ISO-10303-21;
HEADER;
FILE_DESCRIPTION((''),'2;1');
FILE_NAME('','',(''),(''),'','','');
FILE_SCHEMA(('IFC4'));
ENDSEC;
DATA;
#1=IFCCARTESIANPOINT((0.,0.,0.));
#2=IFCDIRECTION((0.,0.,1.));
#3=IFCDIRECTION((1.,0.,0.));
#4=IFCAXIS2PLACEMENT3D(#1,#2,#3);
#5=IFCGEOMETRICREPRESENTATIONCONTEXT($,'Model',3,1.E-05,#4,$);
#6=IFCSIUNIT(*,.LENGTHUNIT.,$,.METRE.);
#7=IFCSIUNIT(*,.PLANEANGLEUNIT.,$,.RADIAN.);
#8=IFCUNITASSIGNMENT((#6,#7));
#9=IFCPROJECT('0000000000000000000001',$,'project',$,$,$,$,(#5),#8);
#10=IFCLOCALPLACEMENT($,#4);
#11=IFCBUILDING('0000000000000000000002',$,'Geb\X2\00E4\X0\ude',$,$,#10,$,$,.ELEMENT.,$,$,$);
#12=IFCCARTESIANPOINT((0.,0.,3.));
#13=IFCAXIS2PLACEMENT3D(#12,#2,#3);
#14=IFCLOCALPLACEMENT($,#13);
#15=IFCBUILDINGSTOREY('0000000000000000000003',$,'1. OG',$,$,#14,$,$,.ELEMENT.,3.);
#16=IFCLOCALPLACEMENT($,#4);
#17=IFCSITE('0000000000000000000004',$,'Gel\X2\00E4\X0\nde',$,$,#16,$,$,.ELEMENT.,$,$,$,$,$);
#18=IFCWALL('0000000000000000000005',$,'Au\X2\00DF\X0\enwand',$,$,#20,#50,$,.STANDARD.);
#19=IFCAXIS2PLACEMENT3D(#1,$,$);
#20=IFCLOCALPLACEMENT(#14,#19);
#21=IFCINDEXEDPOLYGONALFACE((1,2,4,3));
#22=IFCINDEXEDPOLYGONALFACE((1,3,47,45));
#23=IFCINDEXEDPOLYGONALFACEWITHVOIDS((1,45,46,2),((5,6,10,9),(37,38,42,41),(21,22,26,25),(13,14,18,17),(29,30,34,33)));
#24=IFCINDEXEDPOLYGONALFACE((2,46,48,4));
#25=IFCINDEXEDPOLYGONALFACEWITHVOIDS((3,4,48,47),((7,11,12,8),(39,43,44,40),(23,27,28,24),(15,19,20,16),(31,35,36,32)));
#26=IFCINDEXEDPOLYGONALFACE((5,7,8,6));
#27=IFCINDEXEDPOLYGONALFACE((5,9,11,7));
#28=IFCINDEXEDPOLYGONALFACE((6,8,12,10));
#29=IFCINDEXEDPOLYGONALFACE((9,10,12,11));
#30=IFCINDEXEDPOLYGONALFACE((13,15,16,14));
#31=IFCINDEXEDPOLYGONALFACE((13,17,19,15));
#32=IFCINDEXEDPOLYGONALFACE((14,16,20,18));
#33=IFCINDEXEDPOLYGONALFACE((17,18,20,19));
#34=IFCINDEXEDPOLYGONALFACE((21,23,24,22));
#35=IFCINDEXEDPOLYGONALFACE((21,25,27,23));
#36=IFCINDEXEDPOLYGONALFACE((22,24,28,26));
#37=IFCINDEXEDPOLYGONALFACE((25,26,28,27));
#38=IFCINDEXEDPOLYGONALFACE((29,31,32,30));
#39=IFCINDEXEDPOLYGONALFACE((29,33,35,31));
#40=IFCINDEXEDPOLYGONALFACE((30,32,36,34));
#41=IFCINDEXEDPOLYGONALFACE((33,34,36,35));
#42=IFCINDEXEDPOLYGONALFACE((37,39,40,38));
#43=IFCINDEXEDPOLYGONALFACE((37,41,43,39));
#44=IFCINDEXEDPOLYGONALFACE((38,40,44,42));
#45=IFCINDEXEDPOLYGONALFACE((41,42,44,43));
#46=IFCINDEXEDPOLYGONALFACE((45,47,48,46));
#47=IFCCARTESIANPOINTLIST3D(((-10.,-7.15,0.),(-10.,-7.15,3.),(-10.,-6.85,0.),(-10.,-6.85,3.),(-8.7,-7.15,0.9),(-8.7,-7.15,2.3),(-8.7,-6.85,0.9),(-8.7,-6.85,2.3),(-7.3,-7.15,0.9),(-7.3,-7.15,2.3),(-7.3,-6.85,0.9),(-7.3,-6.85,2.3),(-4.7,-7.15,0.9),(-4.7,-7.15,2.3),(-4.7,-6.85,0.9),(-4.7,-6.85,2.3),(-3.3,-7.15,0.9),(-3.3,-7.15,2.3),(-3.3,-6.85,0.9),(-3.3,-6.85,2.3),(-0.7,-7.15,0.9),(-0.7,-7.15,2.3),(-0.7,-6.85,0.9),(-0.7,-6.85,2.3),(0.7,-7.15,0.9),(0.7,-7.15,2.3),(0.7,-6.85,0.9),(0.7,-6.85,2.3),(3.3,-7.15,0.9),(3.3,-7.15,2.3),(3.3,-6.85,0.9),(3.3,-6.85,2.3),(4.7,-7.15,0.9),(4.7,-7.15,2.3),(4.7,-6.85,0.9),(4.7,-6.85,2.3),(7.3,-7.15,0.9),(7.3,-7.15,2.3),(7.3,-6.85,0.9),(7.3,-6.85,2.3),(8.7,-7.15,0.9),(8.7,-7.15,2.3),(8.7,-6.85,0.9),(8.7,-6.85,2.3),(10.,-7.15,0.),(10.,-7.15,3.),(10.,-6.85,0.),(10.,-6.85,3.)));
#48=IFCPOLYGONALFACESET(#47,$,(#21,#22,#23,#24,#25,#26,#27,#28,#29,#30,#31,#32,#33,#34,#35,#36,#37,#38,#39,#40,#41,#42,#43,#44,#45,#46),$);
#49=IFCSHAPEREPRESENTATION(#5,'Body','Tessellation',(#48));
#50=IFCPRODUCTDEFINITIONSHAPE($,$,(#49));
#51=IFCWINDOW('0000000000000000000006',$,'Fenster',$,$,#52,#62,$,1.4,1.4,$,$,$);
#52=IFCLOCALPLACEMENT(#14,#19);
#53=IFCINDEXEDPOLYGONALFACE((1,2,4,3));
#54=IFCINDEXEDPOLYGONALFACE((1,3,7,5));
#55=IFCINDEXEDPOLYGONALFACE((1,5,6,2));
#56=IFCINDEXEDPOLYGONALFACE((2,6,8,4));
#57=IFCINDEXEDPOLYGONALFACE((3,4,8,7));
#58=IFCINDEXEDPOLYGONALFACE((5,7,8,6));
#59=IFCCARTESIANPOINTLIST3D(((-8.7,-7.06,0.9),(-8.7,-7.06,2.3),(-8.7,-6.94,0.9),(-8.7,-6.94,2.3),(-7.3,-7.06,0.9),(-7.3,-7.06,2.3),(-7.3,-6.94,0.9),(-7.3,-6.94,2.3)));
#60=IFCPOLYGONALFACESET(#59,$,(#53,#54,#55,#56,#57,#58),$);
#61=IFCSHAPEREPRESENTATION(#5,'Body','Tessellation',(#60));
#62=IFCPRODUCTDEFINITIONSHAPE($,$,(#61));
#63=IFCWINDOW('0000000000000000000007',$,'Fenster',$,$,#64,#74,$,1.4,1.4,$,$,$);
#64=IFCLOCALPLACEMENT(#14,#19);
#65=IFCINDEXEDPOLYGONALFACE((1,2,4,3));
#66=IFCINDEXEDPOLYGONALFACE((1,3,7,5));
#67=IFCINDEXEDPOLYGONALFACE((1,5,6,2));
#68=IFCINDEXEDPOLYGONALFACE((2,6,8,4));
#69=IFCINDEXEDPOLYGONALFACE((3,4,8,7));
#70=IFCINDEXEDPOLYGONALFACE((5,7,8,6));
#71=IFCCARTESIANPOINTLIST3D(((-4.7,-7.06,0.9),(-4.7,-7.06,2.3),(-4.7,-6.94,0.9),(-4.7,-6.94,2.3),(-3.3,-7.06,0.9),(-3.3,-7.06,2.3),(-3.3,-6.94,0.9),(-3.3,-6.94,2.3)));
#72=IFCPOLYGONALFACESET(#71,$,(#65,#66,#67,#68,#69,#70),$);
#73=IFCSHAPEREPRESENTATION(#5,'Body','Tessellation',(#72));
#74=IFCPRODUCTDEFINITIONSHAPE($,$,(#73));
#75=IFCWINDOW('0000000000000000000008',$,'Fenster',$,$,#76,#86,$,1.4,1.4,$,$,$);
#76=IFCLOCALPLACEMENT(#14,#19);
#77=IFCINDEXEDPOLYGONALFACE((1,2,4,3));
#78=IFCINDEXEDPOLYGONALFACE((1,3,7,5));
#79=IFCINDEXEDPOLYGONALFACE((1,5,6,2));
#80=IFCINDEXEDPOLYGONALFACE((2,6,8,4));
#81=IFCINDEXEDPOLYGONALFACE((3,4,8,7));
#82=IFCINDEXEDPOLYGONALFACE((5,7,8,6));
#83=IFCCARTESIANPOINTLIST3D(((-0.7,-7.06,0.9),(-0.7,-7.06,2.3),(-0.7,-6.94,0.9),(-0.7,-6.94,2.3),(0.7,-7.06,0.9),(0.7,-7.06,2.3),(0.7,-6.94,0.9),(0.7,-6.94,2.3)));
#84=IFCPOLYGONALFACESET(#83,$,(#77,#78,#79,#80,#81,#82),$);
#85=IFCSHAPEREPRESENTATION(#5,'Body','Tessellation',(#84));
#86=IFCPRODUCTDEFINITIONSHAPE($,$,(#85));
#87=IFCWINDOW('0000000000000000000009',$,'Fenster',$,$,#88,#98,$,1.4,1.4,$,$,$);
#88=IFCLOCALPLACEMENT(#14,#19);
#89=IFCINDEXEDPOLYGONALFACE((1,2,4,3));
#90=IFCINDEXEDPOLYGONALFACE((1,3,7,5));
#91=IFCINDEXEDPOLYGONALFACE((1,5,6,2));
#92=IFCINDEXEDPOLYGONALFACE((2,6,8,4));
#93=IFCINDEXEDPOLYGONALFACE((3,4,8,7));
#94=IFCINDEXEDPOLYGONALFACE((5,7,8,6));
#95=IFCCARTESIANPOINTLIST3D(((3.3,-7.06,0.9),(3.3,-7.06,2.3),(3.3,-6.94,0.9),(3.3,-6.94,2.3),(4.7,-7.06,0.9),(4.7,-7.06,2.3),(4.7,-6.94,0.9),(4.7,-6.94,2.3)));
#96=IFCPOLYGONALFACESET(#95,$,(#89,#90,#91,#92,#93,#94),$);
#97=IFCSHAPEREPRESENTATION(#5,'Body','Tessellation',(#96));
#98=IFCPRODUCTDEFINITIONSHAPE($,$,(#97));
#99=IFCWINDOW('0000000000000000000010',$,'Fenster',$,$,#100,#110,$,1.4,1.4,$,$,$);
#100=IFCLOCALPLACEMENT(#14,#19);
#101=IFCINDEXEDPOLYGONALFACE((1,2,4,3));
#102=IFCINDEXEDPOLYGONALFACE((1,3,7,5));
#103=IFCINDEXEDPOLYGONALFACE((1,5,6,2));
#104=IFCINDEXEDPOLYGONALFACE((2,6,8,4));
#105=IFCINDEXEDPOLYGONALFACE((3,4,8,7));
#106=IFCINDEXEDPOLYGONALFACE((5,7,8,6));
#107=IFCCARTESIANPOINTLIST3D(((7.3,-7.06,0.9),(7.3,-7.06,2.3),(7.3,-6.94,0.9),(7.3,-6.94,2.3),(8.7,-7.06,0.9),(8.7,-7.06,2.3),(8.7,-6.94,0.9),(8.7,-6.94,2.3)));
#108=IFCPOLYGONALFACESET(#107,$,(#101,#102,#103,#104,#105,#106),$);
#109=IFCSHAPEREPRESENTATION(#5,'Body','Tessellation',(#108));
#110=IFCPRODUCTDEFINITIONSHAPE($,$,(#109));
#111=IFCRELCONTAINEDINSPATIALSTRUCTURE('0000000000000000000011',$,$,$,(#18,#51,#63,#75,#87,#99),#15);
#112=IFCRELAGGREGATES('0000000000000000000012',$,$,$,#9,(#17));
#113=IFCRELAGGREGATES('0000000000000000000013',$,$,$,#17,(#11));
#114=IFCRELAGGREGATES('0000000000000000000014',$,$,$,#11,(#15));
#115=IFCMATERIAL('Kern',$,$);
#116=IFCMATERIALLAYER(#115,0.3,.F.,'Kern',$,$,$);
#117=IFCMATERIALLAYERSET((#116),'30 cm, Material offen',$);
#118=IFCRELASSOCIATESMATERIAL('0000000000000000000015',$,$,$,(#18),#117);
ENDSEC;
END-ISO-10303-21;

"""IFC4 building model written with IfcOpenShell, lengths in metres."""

from ifc_helpers import new_model, si_unit, frame, origin_with_axes, origin_2d, place, context, project, spatial, rectangle, extrude, material, layer, layer_set, element, fill, save


model = new_model("IFC4")

# Units and contexts
model_context = context("Model", 3, precision=1e-05, world=origin_with_axes())
ifc_project = project(units=[si_unit("LENGTHUNIT", "METRE"), si_unit("PLANEANGLEUNIT", "RADIAN")], contexts=[model_context])

# Site, building, storey
site_placement = place(None, origin_with_axes())
site = spatial("IfcSite", under=ifc_project, at=site_placement, Name="Gelände", CompositionType="ELEMENT")
building_placement = place(None, origin_with_axes())
building = spatial("IfcBuilding", under=site, at=building_placement, Name="Gebäude", CompositionType="ELEMENT")
storey_placement = place(None, frame((0.0, 0.0, 3.0), z_axis=(0.0, 0.0, 1.0), x_axis=(1.0, 0.0, 0.0)))
storey = spatial("IfcBuildingStorey", under=building, at=storey_placement, Name="1. OG", CompositionType="ELEMENT", Elevation=3.0)

# Wall, openings, windows
ifc_material = material(Name="Kern")
ifc_layer = layer(ifc_material, 0.3, ventilated=False, Name="Kern")
ifc_layer_set = layer_set([ifc_layer], Name="30 cm, Material offen")
wall_1_placement = place(None, frame((0.0, -7.0, 3.0), z_axis=(0.0, 0.0, 1.0), x_axis=(1.0, 0.0, 0.0)))
wall_1 = element("IfcWall", 1, at=wall_1_placement, inside=storey, material=ifc_layer_set, Name="Außenwand", PredefinedType="STANDARD", context=model_context, shape_type="SweptSolid", body=[
    extrude(rectangle(XDim=20.0, YDim=0.3, at=origin_2d()), origin_with_axes(), (0.0, 0.0, 1.0), 3.0),
])
opening_1_placement = place(wall_1_placement, frame((-8.0, 0.0, 0.9), z_axis=(0.0, 0.0, 1.0), x_axis=(1.0, 0.0, 0.0)))
opening_1 = element("IfcOpeningElement", 2, at=opening_1_placement, cuts=wall_1, PredefinedType="OPENING", context=model_context, shape_type="SweptSolid", body=[
    extrude(rectangle(XDim=1.4, YDim=0.34, at=origin_2d()), origin_with_axes(), (0.0, 0.0, 1.0), 1.4),
])
opening_2_placement = place(wall_1_placement, frame((-4.0, 0.0, 0.9), z_axis=(0.0, 0.0, 1.0), x_axis=(1.0, 0.0, 0.0)))
opening_2 = element("IfcOpeningElement", 3, at=opening_2_placement, cuts=wall_1, PredefinedType="OPENING", context=model_context, shape_type="SweptSolid", body=[
    extrude(rectangle(XDim=1.4, YDim=0.34, at=origin_2d()), origin_with_axes(), (0.0, 0.0, 1.0), 1.4),
])
opening_3_placement = place(wall_1_placement, frame((0.0, 0.0, 0.9), z_axis=(0.0, 0.0, 1.0), x_axis=(1.0, 0.0, 0.0)))
opening_3 = element("IfcOpeningElement", 4, at=opening_3_placement, cuts=wall_1, PredefinedType="OPENING", context=model_context, shape_type="SweptSolid", body=[
    extrude(rectangle(XDim=1.4, YDim=0.34, at=origin_2d()), origin_with_axes(), (0.0, 0.0, 1.0), 1.4),
])
opening_4_placement = place(wall_1_placement, frame((4.0, 0.0, 0.9), z_axis=(0.0, 0.0, 1.0), x_axis=(1.0, 0.0, 0.0)))
opening_4 = element("IfcOpeningElement", 5, at=opening_4_placement, cuts=wall_1, PredefinedType="OPENING", context=model_context, shape_type="SweptSolid", body=[
    extrude(rectangle(XDim=1.4, YDim=0.34, at=origin_2d()), origin_with_axes(), (0.0, 0.0, 1.0), 1.4),
])
opening_5_placement = place(wall_1_placement, frame((8.0, 0.0, 0.9), z_axis=(0.0, 0.0, 1.0), x_axis=(1.0, 0.0, 0.0)))
opening_5 = element("IfcOpeningElement", 6, at=opening_5_placement, cuts=wall_1, PredefinedType="OPENING", context=model_context, shape_type="SweptSolid", body=[
    extrude(rectangle(XDim=1.4, YDim=0.34, at=origin_2d()), origin_with_axes(), (0.0, 0.0, 1.0), 1.4),
])
window_1_placement = place(opening_1_placement, origin_with_axes())
window_1 = element("IfcWindow", 7, at=window_1_placement, inside=storey, Name="Fenster", OverallHeight=1.4, OverallWidth=1.4, context=model_context, shape_type="SweptSolid", body=[
    extrude(rectangle(XDim=1.4, YDim=0.12, at=origin_2d()), origin_with_axes(), (0.0, 0.0, 1.0), 1.4),
])
fill(opening_1, window_1)
window_2_placement = place(opening_2_placement, origin_with_axes())
window_2 = element("IfcWindow", 8, at=window_2_placement, inside=storey, Name="Fenster", OverallHeight=1.4, OverallWidth=1.4, context=model_context, shape_type="SweptSolid", body=[
    extrude(rectangle(XDim=1.4, YDim=0.12, at=origin_2d()), origin_with_axes(), (0.0, 0.0, 1.0), 1.4),
])
fill(opening_2, window_2)
window_3_placement = place(opening_3_placement, origin_with_axes())
window_3 = element("IfcWindow", 9, at=window_3_placement, inside=storey, Name="Fenster", OverallHeight=1.4, OverallWidth=1.4, context=model_context, shape_type="SweptSolid", body=[
    extrude(rectangle(XDim=1.4, YDim=0.12, at=origin_2d()), origin_with_axes(), (0.0, 0.0, 1.0), 1.4),
])
fill(opening_3, window_3)
window_4_placement = place(opening_4_placement, origin_with_axes())
window_4 = element("IfcWindow", 10, at=window_4_placement, inside=storey, Name="Fenster", OverallHeight=1.4, OverallWidth=1.4, context=model_context, shape_type="SweptSolid", body=[
    extrude(rectangle(XDim=1.4, YDim=0.12, at=origin_2d()), origin_with_axes(), (0.0, 0.0, 1.0), 1.4),
])
fill(opening_4, window_4)
window_5_placement = place(opening_5_placement, origin_with_axes())
window_5 = element("IfcWindow", 11, at=window_5_placement, inside=storey, Name="Fenster", OverallHeight=1.4, OverallWidth=1.4, context=model_context, shape_type="SweptSolid", body=[
    extrude(rectangle(XDim=1.4, YDim=0.12, at=origin_2d()), origin_with_axes(), (0.0, 0.0, 1.0), 1.4),
])
fill(opening_5, window_5)

save(model, "model.ifc")
